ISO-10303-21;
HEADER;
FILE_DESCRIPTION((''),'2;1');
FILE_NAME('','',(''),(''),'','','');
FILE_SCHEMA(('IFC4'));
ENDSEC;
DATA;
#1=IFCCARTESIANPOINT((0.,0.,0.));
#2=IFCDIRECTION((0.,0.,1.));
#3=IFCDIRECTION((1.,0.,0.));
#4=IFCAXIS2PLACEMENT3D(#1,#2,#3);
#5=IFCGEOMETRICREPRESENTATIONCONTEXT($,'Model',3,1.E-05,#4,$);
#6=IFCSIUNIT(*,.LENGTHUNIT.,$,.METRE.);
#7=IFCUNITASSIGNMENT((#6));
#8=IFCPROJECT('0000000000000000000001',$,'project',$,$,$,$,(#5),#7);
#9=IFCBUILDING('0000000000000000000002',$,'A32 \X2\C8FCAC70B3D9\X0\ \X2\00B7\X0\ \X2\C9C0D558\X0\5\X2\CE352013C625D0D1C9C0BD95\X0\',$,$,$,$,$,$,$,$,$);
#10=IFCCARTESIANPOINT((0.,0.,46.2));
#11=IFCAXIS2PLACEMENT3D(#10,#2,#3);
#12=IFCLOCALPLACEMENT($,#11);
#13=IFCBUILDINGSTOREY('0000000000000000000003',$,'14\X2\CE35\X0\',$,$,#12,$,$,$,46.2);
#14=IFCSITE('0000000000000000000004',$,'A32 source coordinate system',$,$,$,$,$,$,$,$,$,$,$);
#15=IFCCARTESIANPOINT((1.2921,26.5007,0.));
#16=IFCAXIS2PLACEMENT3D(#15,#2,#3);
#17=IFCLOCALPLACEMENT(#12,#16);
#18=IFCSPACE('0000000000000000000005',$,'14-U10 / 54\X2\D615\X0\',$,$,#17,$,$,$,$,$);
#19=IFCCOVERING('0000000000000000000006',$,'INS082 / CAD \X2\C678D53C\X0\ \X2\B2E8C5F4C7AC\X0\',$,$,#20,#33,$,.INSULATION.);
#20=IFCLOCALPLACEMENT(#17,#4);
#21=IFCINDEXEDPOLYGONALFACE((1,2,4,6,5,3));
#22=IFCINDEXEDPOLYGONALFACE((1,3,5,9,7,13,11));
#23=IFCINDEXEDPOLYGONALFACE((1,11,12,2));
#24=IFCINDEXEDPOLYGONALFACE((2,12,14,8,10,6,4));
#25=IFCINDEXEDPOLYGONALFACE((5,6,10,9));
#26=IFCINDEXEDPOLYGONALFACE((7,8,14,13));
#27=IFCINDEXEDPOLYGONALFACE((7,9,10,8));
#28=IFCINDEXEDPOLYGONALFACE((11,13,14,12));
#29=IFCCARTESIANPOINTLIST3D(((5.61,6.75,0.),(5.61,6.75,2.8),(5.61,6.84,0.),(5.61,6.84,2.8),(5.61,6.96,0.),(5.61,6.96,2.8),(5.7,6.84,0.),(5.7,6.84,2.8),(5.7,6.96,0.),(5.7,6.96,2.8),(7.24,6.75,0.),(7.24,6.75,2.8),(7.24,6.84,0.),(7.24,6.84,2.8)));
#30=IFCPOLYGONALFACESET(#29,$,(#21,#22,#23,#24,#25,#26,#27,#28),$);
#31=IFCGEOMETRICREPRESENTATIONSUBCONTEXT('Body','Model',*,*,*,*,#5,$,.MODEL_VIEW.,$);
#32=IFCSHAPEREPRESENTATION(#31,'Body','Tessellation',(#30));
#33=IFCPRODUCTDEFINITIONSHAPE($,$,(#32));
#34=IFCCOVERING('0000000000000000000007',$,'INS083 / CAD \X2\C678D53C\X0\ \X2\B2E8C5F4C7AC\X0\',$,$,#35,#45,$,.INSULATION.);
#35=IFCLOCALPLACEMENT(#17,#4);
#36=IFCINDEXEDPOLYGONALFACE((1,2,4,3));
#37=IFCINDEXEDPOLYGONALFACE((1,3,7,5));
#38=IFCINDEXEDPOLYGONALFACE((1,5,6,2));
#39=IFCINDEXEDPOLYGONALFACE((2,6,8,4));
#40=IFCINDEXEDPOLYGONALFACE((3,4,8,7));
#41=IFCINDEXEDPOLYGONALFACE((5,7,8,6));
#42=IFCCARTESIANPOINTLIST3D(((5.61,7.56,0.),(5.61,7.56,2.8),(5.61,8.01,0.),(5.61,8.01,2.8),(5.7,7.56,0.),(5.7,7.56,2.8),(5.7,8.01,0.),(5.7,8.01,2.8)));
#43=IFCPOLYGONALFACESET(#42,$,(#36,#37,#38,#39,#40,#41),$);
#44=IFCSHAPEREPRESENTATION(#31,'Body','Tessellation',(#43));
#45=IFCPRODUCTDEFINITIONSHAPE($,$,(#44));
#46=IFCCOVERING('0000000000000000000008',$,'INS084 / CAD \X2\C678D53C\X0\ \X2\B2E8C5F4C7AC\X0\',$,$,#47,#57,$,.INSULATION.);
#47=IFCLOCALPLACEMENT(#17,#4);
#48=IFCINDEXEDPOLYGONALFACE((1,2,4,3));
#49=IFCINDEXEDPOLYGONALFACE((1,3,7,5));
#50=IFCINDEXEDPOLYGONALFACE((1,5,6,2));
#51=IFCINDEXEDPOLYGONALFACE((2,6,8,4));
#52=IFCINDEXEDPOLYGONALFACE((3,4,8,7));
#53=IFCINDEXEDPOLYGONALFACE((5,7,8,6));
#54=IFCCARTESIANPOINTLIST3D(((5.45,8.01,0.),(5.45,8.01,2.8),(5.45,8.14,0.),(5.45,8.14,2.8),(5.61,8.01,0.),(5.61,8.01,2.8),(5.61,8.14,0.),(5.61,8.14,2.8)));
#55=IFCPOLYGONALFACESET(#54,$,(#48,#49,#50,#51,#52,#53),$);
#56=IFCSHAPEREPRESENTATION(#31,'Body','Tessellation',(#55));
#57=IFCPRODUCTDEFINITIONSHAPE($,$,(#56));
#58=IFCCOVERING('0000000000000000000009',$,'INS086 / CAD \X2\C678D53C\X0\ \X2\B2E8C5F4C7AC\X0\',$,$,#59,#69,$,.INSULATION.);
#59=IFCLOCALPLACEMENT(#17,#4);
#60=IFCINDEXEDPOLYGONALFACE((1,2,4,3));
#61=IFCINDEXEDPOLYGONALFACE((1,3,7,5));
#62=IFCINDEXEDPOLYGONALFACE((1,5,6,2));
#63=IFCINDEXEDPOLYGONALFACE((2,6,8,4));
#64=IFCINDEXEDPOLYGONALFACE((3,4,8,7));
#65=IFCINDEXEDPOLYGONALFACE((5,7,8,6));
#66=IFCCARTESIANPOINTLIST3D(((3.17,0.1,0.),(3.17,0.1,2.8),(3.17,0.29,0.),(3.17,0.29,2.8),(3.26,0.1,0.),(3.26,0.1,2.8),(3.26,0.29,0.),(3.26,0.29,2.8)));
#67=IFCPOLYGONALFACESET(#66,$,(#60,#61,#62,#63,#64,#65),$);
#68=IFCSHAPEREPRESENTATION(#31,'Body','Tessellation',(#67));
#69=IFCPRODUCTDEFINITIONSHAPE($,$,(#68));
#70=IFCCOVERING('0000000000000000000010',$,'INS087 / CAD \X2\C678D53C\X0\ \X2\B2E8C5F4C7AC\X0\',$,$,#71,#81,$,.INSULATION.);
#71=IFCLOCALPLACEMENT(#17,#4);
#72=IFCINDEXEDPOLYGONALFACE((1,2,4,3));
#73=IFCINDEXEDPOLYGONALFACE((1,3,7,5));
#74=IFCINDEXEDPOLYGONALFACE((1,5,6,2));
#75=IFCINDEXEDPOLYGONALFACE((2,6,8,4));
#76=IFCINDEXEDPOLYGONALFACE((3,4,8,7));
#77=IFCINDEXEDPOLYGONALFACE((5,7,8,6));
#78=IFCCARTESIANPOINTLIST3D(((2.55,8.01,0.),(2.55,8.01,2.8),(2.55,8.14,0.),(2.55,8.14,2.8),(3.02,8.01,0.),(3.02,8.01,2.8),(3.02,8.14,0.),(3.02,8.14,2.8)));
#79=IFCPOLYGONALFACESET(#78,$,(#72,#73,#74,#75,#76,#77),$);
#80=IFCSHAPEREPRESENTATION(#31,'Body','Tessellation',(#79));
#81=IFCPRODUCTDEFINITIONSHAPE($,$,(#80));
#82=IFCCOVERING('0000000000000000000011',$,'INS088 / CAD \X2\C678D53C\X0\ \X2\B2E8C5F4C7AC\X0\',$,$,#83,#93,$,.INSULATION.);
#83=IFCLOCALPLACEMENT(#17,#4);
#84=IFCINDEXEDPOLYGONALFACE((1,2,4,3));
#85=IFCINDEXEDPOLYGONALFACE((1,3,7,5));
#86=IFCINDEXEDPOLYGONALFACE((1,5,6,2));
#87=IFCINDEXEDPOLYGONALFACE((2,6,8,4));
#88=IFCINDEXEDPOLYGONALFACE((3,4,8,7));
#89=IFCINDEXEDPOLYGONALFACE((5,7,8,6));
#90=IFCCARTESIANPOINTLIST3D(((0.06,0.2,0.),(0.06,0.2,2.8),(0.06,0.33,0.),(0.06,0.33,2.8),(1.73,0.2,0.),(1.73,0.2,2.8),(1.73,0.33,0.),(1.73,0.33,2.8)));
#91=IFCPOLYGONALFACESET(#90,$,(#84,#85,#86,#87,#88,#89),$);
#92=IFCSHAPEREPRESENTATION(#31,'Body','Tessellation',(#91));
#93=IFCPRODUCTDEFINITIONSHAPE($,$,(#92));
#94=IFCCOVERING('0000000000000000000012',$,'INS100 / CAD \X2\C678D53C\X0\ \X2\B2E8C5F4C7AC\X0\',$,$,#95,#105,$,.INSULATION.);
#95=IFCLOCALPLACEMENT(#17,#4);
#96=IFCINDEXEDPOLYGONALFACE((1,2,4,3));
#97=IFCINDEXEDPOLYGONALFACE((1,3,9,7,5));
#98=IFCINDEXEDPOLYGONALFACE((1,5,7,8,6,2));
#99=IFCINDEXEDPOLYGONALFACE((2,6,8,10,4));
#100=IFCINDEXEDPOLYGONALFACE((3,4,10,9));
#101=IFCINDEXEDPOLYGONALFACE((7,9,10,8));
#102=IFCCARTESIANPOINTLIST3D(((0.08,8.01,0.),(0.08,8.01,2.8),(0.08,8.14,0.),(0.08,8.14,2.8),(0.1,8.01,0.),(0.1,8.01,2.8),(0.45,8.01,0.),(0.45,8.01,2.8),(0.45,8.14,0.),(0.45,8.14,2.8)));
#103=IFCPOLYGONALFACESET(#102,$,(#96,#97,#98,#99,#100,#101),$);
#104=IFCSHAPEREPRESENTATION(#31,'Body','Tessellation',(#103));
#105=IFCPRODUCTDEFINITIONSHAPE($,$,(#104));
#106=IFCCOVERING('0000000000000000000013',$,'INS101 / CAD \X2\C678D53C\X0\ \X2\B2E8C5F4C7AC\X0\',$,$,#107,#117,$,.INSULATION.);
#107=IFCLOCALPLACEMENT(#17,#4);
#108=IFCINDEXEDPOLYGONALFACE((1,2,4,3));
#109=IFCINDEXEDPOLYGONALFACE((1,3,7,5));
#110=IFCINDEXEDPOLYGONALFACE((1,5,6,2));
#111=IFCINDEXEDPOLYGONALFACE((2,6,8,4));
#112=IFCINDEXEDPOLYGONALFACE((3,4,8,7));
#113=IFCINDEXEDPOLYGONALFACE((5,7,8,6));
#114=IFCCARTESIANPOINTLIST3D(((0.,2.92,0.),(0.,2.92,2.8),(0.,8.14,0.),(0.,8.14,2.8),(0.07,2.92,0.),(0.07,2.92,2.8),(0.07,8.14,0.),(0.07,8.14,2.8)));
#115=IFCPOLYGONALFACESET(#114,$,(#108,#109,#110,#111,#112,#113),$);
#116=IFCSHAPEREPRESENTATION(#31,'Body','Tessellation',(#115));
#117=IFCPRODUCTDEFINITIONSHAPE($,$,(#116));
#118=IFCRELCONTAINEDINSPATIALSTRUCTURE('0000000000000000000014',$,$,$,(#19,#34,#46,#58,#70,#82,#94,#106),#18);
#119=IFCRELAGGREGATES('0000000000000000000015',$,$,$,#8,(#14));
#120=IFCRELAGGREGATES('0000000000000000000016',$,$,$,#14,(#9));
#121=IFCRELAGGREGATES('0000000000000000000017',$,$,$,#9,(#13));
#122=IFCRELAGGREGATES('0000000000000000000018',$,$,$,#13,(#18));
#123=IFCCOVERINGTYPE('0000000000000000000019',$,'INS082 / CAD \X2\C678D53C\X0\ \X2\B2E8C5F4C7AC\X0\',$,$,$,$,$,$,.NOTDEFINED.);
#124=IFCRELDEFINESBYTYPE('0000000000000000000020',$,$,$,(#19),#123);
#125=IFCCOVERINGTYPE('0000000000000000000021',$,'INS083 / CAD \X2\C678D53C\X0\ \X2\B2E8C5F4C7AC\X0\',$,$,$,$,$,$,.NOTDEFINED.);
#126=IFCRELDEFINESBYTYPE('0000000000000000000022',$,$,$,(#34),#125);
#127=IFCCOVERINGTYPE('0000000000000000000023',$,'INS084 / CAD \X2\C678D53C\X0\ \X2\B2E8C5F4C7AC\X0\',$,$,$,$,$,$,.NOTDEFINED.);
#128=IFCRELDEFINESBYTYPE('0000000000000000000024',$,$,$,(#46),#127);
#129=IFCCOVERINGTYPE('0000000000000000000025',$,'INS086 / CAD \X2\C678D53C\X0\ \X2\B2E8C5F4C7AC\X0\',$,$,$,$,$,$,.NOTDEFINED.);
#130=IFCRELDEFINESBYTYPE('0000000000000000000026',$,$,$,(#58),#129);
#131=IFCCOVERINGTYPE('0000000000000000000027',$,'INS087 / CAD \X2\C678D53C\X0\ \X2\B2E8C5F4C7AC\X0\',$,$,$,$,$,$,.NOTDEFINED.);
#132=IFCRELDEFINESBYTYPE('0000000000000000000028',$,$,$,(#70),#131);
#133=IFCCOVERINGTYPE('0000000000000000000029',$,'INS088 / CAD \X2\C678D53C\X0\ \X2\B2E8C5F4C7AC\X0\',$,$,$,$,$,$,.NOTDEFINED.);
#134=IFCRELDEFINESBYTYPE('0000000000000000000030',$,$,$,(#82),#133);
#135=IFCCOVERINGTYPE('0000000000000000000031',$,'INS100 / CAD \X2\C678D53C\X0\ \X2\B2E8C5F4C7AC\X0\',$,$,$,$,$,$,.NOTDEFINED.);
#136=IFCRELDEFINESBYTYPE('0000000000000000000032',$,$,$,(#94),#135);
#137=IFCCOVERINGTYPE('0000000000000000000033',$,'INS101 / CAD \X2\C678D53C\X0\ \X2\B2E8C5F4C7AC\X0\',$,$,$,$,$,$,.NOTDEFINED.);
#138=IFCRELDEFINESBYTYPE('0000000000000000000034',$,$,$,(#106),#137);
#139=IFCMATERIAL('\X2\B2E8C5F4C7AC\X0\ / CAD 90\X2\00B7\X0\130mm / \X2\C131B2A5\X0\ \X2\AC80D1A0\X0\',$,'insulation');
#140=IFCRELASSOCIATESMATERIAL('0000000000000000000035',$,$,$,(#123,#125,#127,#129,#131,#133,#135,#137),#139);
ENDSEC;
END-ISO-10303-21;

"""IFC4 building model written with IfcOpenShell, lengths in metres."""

from ifc_helpers import new_model, si_unit, frame, origin, origin_with_axes, place, context, subcontext, project, spatial, polyline, outline, extrude, source, transform, mapped, material, type_object, type_shapes, element, save


model = new_model("IFC4")

# Units and contexts
model_context = context("Model", 3, precision=1e-05, world=origin_with_axes())
body_context = subcontext(model_context, "Body", "Model", "MODEL_VIEW")
ifc_project = project(units=[si_unit("LENGTHUNIT", "METRE")], contexts=[model_context])

# Site, building, storey, space
storey_placement = place(None, frame((0.0, 0.0, 46.2), z_axis=(0.0, 0.0, 1.0), x_axis=(1.0, 0.0, 0.0)))
space_placement = place(storey_placement, frame((1.2921, 26.5007, 0.0), z_axis=(0.0, 0.0, 1.0), x_axis=(1.0, 0.0, 0.0)))
site = spatial("IfcSite", under=ifc_project, Name="A32 source coordinate system")
building = spatial("IfcBuilding", under=site, Name="A32 주거동 · 지하5층–옥탑지붕")
storey = spatial("IfcBuildingStorey", under=building, at=storey_placement, Name="14층", Elevation=46.2)
space = spatial("IfcSpace", under=storey, at=space_placement, Name="14-U10 / 54형")

# Coverings
ifc_material = material(Name="단열재 / CAD 90·130mm / 성능 검토", Category="insulation")
covering_type_1 = type_object("IfcCoveringType", Name="INS082 / CAD 외피 단열재", PredefinedType="NOTDEFINED", material=ifc_material)
shared_shape_1 = source(origin(), body_context, "Body", "SweptSolid", [
    extrude(outline(polyline([(5.61, 6.84), (5.61, 6.96), (5.7, 6.96), (5.7, 6.84), (7.24, 6.84), (7.24, 6.75), (5.61, 6.75), (5.61, 6.84)])), origin(), (0.0, 0.0, 1.0), 2.8),
])
type_shapes(covering_type_1, [shared_shape_1])
covering_1_placement = place(space_placement, origin_with_axes())
element("IfcCovering", 1, at=covering_1_placement, inside=space, type_object=covering_type_1, Name="INS082 / CAD 외피 단열재", PredefinedType="INSULATION", context=body_context, shape_type="MappedRepresentation", body=[
    mapped(shared_shape_1, transform((0.0, 0.0, 0.0), scale=1.0)),
])
covering_type_2 = type_object("IfcCoveringType", Name="INS083 / CAD 외피 단열재", PredefinedType="NOTDEFINED", material=ifc_material)
shared_shape_2 = source(origin(), body_context, "Body", "SweptSolid", [
    extrude(outline(polyline([(5.61, 8.01), (5.7, 8.01), (5.7, 7.56), (5.61, 7.56), (5.61, 8.01)])), origin(), (0.0, 0.0, 1.0), 2.8),
])
type_shapes(covering_type_2, [shared_shape_2])
covering_2_placement = place(space_placement, origin_with_axes())
element("IfcCovering", 2, at=covering_2_placement, inside=space, type_object=covering_type_2, Name="INS083 / CAD 외피 단열재", PredefinedType="INSULATION", context=body_context, shape_type="MappedRepresentation", body=[
    mapped(shared_shape_2, transform((0.0, 0.0, 0.0), scale=1.0)),
])
covering_type_3 = type_object("IfcCoveringType", Name="INS084 / CAD 외피 단열재", PredefinedType="NOTDEFINED", material=ifc_material)
shared_shape_3 = source(origin(), body_context, "Body", "SweptSolid", [
    extrude(outline(polyline([(5.45, 8.01), (5.45, 8.14), (5.61, 8.14), (5.61, 8.01), (5.45, 8.01)])), origin(), (0.0, 0.0, 1.0), 2.8),
])
type_shapes(covering_type_3, [shared_shape_3])
covering_3_placement = place(space_placement, origin_with_axes())
element("IfcCovering", 3, at=covering_3_placement, inside=space, type_object=covering_type_3, Name="INS084 / CAD 외피 단열재", PredefinedType="INSULATION", context=body_context, shape_type="MappedRepresentation", body=[
    mapped(shared_shape_3, transform((0.0, 0.0, 0.0), scale=1.0)),
])
covering_type_4 = type_object("IfcCoveringType", Name="INS086 / CAD 외피 단열재", PredefinedType="NOTDEFINED", material=ifc_material)
shared_shape_4 = source(origin(), body_context, "Body", "SweptSolid", [
    extrude(outline(polyline([(3.17, 0.1), (3.17, 0.29), (3.26, 0.29), (3.26, 0.1), (3.17, 0.1)])), origin(), (0.0, 0.0, 1.0), 2.8),
])
type_shapes(covering_type_4, [shared_shape_4])
covering_4_placement = place(space_placement, origin_with_axes())
element("IfcCovering", 4, at=covering_4_placement, inside=space, type_object=covering_type_4, Name="INS086 / CAD 외피 단열재", PredefinedType="INSULATION", context=body_context, shape_type="MappedRepresentation", body=[
    mapped(shared_shape_4, transform((0.0, 0.0, 0.0), scale=1.0)),
])
covering_type_5 = type_object("IfcCoveringType", Name="INS087 / CAD 외피 단열재", PredefinedType="NOTDEFINED", material=ifc_material)
shared_shape_5 = source(origin(), body_context, "Body", "SweptSolid", [
    extrude(outline(polyline([(2.55, 8.14), (3.02, 8.14), (3.02, 8.01), (2.55, 8.01), (2.55, 8.14)])), origin(), (0.0, 0.0, 1.0), 2.8),
])
type_shapes(covering_type_5, [shared_shape_5])
covering_5_placement = place(space_placement, origin_with_axes())
element("IfcCovering", 5, at=covering_5_placement, inside=space, type_object=covering_type_5, Name="INS087 / CAD 외피 단열재", PredefinedType="INSULATION", context=body_context, shape_type="MappedRepresentation", body=[
    mapped(shared_shape_5, transform((0.0, 0.0, 0.0), scale=1.0)),
])
covering_type_6 = type_object("IfcCoveringType", Name="INS088 / CAD 외피 단열재", PredefinedType="NOTDEFINED", material=ifc_material)
shared_shape_6 = source(origin(), body_context, "Body", "SweptSolid", [
    extrude(outline(polyline([(0.06, 0.33), (1.73, 0.33), (1.73, 0.2), (0.06, 0.2), (0.06, 0.33)])), origin(), (0.0, 0.0, 1.0), 2.8),
])
type_shapes(covering_type_6, [shared_shape_6])
covering_6_placement = place(space_placement, origin_with_axes())
element("IfcCovering", 6, at=covering_6_placement, inside=space, type_object=covering_type_6, Name="INS088 / CAD 외피 단열재", PredefinedType="INSULATION", context=body_context, shape_type="MappedRepresentation", body=[
    mapped(shared_shape_6, transform((0.0, 0.0, 0.0), scale=1.0)),
])
covering_type_7 = type_object("IfcCoveringType", Name="INS100 / CAD 외피 단열재", PredefinedType="NOTDEFINED", material=ifc_material)
shared_shape_7 = source(origin(), body_context, "Body", "SweptSolid", [
    extrude(outline(polyline([(0.08, 8.01), (0.08, 8.14), (0.45, 8.14), (0.45, 8.01), (0.1, 8.01), (0.08, 8.01)])), origin(), (0.0, 0.0, 1.0), 2.8),
])
type_shapes(covering_type_7, [shared_shape_7])
covering_7_placement = place(space_placement, origin_with_axes())
element("IfcCovering", 7, at=covering_7_placement, inside=space, type_object=covering_type_7, Name="INS100 / CAD 외피 단열재", PredefinedType="INSULATION", context=body_context, shape_type="MappedRepresentation", body=[
    mapped(shared_shape_7, transform((0.0, 0.0, 0.0), scale=1.0)),
])
covering_type_8 = type_object("IfcCoveringType", Name="INS101 / CAD 외피 단열재", PredefinedType="NOTDEFINED", material=ifc_material)
shared_shape_8 = source(origin(), body_context, "Body", "SweptSolid", [
    extrude(outline(polyline([(0.0, 2.92), (0.0, 8.14), (0.07, 8.14), (0.07, 2.92), (0.0, 2.92)])), origin(), (0.0, 0.0, 1.0), 2.8),
])
type_shapes(covering_type_8, [shared_shape_8])
covering_8_placement = place(space_placement, origin_with_axes())
element("IfcCovering", 8, at=covering_8_placement, inside=space, type_object=covering_type_8, Name="INS101 / CAD 외피 단열재", PredefinedType="INSULATION", context=body_context, shape_type="MappedRepresentation", body=[
    mapped(shared_shape_8, transform((0.0, 0.0, 0.0), scale=1.0)),
])

save(model, "model.ifc")
